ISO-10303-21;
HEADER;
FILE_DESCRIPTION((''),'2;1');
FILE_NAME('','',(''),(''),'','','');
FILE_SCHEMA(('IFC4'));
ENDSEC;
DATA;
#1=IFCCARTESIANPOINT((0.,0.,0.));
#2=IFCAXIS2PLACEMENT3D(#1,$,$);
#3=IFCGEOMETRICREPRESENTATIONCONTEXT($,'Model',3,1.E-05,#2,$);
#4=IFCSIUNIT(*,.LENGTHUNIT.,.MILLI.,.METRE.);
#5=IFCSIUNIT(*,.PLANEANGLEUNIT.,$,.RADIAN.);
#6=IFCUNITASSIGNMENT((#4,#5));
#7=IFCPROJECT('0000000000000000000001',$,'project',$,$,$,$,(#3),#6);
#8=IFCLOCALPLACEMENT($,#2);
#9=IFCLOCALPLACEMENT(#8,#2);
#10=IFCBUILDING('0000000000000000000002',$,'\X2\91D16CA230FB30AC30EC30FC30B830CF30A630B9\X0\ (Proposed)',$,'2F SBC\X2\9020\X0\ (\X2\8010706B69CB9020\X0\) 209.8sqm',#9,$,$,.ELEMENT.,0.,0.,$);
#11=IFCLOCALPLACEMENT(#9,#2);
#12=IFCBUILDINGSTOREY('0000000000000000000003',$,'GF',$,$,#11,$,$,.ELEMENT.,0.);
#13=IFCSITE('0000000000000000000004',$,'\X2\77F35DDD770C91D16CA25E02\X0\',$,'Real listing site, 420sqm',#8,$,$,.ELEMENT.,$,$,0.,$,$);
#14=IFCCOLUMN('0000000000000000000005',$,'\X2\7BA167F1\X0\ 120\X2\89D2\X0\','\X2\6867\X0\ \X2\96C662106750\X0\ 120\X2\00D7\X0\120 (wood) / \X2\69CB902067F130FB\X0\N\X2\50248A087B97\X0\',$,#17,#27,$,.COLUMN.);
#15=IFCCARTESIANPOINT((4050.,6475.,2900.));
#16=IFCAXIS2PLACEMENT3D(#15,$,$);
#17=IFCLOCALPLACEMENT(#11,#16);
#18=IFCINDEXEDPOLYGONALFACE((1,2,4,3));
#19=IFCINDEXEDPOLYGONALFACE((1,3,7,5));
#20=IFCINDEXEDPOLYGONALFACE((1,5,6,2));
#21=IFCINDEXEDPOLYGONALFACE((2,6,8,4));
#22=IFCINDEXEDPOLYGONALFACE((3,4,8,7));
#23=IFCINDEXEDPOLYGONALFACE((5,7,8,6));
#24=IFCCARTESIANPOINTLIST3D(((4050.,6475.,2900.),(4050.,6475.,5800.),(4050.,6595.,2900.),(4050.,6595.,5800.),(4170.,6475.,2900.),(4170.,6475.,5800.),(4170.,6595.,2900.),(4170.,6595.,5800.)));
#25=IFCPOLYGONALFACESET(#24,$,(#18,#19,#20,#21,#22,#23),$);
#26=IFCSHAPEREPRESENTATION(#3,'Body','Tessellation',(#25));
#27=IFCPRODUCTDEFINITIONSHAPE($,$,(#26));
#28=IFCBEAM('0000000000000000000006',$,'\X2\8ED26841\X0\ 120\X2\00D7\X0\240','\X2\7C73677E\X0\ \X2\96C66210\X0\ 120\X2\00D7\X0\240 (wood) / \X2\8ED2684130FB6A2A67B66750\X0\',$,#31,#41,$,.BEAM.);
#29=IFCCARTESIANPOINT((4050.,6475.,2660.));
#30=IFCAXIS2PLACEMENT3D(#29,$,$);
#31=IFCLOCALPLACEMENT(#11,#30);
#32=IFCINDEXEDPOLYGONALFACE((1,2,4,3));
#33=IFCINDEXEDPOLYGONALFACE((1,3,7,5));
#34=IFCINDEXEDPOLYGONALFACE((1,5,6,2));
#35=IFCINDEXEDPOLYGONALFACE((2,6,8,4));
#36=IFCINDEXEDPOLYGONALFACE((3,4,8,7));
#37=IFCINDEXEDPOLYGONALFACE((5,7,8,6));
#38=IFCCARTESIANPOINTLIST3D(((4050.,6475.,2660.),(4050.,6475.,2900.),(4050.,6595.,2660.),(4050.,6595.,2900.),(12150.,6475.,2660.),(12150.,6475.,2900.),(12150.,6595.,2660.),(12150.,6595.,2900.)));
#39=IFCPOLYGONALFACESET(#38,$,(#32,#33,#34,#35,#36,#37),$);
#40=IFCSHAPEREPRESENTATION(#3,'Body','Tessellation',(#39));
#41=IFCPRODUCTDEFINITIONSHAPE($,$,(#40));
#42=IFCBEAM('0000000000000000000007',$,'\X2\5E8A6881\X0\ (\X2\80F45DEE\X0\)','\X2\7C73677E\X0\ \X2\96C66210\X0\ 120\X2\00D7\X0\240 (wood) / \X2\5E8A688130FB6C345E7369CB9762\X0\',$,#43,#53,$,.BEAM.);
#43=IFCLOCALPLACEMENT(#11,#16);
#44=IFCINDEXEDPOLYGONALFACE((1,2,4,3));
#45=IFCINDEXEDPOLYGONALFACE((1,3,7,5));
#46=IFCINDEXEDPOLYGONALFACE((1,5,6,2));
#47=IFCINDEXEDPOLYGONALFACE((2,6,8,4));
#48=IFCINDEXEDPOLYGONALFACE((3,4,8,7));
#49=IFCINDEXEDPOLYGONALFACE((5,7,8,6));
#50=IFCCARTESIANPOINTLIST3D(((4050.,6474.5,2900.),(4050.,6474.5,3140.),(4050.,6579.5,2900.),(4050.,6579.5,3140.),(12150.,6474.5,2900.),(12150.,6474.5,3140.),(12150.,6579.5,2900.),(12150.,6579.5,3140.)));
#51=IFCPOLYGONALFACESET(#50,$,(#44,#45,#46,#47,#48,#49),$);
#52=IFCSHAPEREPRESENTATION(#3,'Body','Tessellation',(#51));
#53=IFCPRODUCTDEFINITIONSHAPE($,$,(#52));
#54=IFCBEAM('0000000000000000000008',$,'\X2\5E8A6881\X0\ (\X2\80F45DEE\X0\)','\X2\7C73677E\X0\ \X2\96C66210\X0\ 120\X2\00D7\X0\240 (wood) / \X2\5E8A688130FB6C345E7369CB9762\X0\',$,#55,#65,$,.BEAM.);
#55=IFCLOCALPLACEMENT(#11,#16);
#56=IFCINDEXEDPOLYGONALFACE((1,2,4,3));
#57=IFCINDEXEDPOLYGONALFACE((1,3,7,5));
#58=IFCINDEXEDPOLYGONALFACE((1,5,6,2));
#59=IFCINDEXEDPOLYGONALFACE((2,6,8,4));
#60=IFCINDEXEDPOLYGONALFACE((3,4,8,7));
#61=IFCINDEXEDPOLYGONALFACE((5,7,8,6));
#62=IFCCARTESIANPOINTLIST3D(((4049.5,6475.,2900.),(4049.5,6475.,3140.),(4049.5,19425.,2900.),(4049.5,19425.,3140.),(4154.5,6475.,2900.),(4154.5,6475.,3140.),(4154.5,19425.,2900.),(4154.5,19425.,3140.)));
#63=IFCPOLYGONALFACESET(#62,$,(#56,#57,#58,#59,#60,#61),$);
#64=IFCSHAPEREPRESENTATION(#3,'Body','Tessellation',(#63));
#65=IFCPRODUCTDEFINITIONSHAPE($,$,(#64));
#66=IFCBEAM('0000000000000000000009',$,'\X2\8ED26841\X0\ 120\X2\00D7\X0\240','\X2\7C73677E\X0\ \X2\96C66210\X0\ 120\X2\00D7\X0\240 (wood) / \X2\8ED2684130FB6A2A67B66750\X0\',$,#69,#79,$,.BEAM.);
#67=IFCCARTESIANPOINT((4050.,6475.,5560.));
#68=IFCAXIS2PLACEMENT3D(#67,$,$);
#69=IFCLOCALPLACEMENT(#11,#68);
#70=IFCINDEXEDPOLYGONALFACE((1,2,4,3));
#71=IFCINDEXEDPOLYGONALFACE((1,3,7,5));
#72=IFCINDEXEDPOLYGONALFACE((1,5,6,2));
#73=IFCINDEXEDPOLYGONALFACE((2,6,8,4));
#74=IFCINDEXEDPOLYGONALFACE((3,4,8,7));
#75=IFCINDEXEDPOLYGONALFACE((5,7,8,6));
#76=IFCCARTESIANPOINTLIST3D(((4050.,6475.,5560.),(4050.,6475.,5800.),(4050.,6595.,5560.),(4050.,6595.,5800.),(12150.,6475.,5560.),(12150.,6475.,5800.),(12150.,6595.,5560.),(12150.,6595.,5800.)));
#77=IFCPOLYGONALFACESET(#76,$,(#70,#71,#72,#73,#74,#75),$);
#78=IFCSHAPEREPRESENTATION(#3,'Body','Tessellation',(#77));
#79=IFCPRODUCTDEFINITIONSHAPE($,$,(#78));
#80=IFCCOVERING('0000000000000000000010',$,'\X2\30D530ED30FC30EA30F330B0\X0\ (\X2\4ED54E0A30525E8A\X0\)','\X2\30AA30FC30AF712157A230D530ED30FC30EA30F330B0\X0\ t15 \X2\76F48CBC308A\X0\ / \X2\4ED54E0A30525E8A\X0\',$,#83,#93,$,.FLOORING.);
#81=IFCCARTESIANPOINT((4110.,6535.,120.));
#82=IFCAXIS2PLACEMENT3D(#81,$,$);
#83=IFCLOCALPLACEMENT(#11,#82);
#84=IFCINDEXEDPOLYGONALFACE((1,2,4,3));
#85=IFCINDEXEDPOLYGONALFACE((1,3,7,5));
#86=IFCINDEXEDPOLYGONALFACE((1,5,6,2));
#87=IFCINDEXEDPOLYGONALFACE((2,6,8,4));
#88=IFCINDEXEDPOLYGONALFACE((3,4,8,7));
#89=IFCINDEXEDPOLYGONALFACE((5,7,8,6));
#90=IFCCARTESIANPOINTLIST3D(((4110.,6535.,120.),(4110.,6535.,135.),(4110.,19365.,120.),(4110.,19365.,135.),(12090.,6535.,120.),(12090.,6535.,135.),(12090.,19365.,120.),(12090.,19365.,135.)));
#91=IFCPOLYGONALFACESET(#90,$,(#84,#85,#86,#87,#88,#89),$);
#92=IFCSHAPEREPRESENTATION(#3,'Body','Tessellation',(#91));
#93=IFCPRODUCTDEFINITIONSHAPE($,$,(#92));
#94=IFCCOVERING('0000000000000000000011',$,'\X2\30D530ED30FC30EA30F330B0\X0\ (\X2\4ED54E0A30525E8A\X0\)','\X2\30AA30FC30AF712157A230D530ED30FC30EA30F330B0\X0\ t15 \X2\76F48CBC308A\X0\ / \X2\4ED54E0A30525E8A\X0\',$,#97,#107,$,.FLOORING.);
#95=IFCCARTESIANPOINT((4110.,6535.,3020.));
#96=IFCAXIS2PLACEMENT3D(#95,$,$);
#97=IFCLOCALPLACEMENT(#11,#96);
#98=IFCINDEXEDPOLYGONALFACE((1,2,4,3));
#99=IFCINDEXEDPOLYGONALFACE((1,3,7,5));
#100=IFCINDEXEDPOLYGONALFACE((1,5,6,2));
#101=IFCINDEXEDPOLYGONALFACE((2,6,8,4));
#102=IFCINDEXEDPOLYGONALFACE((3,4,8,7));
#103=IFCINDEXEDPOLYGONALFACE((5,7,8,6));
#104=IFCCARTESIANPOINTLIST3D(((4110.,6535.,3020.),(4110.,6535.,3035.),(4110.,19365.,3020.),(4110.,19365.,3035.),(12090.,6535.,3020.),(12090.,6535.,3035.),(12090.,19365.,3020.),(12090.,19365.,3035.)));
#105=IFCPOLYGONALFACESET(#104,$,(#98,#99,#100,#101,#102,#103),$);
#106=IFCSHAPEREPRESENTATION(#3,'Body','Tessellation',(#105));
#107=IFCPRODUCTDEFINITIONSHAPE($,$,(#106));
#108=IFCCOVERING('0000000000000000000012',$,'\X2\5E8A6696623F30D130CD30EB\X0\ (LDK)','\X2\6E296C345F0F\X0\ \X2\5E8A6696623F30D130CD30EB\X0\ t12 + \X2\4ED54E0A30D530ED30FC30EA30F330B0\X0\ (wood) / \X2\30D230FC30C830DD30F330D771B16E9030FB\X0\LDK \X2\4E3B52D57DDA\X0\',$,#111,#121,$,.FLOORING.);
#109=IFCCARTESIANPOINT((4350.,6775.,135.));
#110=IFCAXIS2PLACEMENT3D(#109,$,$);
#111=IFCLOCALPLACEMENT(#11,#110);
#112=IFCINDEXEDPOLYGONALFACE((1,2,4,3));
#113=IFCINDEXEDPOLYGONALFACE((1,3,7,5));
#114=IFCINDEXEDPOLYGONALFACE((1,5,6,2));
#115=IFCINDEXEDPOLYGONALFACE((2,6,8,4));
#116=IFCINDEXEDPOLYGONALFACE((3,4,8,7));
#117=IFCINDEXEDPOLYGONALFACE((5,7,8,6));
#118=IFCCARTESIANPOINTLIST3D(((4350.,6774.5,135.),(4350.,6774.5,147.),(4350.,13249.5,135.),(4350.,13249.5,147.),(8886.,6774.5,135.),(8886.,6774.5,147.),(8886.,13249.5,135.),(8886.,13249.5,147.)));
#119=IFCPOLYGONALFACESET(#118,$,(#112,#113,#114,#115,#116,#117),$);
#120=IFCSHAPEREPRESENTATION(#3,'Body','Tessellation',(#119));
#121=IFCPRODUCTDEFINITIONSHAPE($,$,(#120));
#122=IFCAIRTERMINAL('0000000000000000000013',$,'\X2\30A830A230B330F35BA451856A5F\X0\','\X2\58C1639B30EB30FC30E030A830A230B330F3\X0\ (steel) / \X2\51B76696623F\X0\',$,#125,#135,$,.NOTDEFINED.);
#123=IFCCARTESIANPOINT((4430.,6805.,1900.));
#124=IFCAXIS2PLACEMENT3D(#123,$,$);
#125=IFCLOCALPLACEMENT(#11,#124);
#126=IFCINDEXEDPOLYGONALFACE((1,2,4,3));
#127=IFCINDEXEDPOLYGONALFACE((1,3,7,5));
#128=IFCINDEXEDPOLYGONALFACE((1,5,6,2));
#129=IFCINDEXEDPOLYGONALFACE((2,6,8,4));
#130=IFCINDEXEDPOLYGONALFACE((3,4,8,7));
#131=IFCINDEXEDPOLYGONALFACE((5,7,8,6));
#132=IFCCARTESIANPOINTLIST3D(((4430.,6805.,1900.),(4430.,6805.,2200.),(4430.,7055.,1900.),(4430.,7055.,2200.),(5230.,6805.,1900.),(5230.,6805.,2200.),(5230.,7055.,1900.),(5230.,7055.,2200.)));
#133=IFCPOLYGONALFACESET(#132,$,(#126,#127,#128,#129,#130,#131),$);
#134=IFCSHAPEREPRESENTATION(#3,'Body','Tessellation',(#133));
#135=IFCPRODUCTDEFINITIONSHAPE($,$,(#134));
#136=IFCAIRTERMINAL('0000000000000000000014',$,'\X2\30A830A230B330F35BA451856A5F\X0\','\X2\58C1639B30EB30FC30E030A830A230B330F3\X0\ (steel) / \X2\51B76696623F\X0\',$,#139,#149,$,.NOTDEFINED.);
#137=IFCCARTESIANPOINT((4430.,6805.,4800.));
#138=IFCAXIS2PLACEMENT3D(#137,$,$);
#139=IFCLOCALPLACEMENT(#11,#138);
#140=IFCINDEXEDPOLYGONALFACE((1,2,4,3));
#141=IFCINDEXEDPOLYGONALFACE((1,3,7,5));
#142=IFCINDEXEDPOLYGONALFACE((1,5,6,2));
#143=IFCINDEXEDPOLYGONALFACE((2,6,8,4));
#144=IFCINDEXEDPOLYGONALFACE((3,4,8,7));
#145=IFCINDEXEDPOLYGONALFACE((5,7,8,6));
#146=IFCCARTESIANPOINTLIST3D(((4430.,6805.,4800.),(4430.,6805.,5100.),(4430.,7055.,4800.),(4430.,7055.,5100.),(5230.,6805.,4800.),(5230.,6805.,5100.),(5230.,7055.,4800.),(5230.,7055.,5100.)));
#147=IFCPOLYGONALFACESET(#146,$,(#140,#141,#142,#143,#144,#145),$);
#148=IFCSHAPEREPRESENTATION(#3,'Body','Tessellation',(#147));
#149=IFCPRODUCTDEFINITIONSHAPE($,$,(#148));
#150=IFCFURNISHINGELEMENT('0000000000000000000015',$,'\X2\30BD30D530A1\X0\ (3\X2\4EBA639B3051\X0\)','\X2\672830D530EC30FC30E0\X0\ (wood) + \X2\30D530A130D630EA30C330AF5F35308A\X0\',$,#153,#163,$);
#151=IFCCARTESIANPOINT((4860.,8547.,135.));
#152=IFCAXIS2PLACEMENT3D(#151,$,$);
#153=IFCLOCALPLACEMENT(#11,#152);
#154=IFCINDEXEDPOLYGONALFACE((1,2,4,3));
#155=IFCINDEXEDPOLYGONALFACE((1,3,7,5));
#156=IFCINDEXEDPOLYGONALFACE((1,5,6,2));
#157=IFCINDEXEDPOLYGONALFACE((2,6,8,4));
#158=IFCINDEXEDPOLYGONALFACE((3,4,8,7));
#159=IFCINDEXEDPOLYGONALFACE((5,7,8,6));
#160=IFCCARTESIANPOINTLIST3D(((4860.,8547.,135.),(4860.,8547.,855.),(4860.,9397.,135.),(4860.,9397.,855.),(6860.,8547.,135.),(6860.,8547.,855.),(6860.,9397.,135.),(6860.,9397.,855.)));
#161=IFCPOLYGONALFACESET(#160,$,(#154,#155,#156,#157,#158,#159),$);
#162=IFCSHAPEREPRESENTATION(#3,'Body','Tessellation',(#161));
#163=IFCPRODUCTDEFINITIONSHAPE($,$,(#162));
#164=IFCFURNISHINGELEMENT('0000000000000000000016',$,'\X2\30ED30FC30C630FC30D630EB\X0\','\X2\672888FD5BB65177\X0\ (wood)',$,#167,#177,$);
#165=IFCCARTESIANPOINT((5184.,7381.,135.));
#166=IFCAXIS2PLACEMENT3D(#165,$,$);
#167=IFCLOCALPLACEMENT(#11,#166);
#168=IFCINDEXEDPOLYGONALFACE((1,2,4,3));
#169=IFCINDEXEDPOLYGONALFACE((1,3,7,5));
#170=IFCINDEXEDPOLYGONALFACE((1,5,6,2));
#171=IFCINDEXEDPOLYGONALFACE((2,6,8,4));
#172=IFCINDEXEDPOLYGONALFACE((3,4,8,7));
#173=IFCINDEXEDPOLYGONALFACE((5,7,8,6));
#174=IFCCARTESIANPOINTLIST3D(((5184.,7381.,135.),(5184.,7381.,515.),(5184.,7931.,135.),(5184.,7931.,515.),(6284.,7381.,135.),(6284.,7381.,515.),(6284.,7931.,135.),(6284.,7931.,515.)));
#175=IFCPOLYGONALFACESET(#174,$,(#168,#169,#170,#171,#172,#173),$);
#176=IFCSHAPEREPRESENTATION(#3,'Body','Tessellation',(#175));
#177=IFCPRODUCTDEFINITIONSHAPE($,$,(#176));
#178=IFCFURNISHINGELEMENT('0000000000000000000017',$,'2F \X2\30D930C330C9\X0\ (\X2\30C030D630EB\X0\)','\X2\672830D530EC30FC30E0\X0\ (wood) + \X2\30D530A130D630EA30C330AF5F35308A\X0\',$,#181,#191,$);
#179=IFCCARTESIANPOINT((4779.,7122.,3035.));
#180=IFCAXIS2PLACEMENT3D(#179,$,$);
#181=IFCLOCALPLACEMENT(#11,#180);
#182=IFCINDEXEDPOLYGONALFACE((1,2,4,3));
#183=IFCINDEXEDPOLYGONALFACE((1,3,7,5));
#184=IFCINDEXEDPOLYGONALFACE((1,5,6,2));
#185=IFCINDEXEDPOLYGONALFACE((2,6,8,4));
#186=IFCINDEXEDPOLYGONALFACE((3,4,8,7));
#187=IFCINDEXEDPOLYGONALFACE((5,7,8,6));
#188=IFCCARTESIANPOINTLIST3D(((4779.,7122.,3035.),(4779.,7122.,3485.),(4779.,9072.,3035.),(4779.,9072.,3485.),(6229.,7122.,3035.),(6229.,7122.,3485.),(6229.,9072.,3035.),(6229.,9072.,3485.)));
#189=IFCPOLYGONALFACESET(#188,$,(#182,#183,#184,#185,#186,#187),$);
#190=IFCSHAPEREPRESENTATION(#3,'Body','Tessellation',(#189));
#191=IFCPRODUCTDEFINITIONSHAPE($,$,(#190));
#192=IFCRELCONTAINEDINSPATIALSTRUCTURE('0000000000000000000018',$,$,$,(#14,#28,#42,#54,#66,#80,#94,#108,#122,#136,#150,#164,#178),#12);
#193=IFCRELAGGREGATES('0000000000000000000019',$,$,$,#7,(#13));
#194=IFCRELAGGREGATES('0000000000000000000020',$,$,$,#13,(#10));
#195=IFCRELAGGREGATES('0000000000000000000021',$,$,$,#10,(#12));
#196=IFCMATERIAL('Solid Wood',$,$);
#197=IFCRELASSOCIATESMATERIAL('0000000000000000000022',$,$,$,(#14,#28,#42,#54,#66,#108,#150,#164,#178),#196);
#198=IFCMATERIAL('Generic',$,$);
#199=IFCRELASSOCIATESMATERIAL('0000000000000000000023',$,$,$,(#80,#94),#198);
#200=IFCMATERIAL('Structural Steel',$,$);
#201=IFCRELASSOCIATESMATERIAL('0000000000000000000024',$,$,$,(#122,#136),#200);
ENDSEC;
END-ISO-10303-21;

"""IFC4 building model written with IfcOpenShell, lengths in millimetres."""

from ifc_helpers import new_model, si_unit, frame, frame_2d, origin, place, context, project, spatial, rectangle, extrude, material, element, save


model = new_model("IFC4")

# Units and contexts
model_context = context("Model", 3, precision=1e-05, world=origin())
ifc_project = project(units=[si_unit("LENGTHUNIT", "METRE", prefix="MILLI"), si_unit("PLANEANGLEUNIT", "RADIAN")], contexts=[model_context])

# Site, building, storey
site_placement = place(None, origin())
site = spatial("IfcSite", under=ifc_project, at=site_placement, Name="石川県金沢市", ObjectType="Real listing site, 420sqm", CompositionType="ELEMENT", RefElevation=0.0)
building_placement = place(site_placement, origin())
building = spatial("IfcBuilding", under=site, at=building_placement, Name="金沢・ガレージハウス (Proposed)", ObjectType="2F SBC造 (耐火構造) 209.8sqm", CompositionType="ELEMENT", ElevationOfRefHeight=0.0, ElevationOfTerrain=0.0)
storey_placement = place(building_placement, origin())
storey = spatial("IfcBuildingStorey", under=building, at=storey_placement, Name="GF", CompositionType="ELEMENT", Elevation=0.0)

# Column
ifc_material_1 = material(Name="Solid Wood")
column_1_placement = place(storey_placement, frame((4050.0, 6475.0, 2900.0)))
element("IfcColumn", 1, at=column_1_placement, inside=storey, material=ifc_material_1, Name="管柱 120角", Description="桧 集成材 120×120 (wood) / 構造柱・N値計算", PredefinedType="COLUMN", context=model_context, shape_type="SweptSolid", body=[
    extrude(rectangle(XDim=120.0, YDim=120.0, at=frame_2d((60.0, 60.0))), frame((4050.0, 6475.0, 2900.0)), (0.0, 0.0, 1.0), 2900.0),
])

# Beams
beam_1_placement = place(storey_placement, frame((4050.0, 6475.0, 2660.0)))
element("IfcBeam", 2, at=beam_1_placement, inside=storey, material=ifc_material_1, Name="軒桁 120×240", Description="米松 集成 120×240 (wood) / 軒桁・横架材", PredefinedType="BEAM", context=model_context, shape_type="SweptSolid", body=[
    extrude(rectangle(XDim=8100.0, YDim=120.0, at=frame_2d((4050.0, 60.0))), frame((4050.0, 6475.0, 2660.0)), (0.0, 0.0, 1.0), 240.0),
])
beam_2_placement = place(storey_placement, frame((4050.0, 6475.0, 2900.0)))
element("IfcBeam", 3, at=beam_2_placement, inside=storey, material=ifc_material_1, Name="床梁 (胴差)", Description="米松 集成 120×240 (wood) / 床梁・水平構面", PredefinedType="BEAM", context=model_context, shape_type="SweptSolid", body=[
    extrude(rectangle(XDim=8100.0, YDim=105.0, at=frame_2d((4050.0, 52.0))), frame((4050.0, 6475.0, 2900.0)), (0.0, 0.0, 1.0), 240.0),
])
beam_3_placement = place(storey_placement, frame((4050.0, 6475.0, 2900.0)))
element("IfcBeam", 4, at=beam_3_placement, inside=storey, material=ifc_material_1, Name="床梁 (胴差)", Description="米松 集成 120×240 (wood) / 床梁・水平構面", PredefinedType="BEAM", context=model_context, shape_type="SweptSolid", body=[
    extrude(rectangle(XDim=105.0, YDim=12950.0, at=frame_2d((52.0, 6475.0))), frame((4050.0, 6475.0, 2900.0)), (0.0, 0.0, 1.0), 240.0),
])
beam_4_placement = place(storey_placement, frame((4050.0, 6475.0, 5560.0)))
element("IfcBeam", 5, at=beam_4_placement, inside=storey, material=ifc_material_1, Name="軒桁 120×240", Description="米松 集成 120×240 (wood) / 軒桁・横架材", PredefinedType="BEAM", context=model_context, shape_type="SweptSolid", body=[
    extrude(rectangle(XDim=8100.0, YDim=120.0, at=frame_2d((4050.0, 60.0))), frame((4050.0, 6475.0, 5560.0)), (0.0, 0.0, 1.0), 240.0),
])

# Coverings
ifc_material_2 = material(Name="Generic")
covering_1_placement = place(storey_placement, frame((4110.0, 6535.0, 120.0)))
element("IfcCovering", 6, at=covering_1_placement, inside=storey, material=ifc_material_2, Name="フローリング (仕上げ床)", Description="オーク無垢フローリング t15 直貼り / 仕上げ床", PredefinedType="FLOORING", context=model_context, shape_type="SweptSolid", body=[
    extrude(rectangle(XDim=7980.0, YDim=12830.0, at=frame_2d((3990.0, 6415.0))), frame((4110.0, 6535.0, 120.0)), (0.0, 0.0, 1.0), 15.0),
])
covering_2_placement = place(storey_placement, frame((4110.0, 6535.0, 3020.0)))
element("IfcCovering", 7, at=covering_2_placement, inside=storey, material=ifc_material_2, Name="フローリング (仕上げ床)", Description="オーク無垢フローリング t15 直貼り / 仕上げ床", PredefinedType="FLOORING", context=model_context, shape_type="SweptSolid", body=[
    extrude(rectangle(XDim=7980.0, YDim=12830.0, at=frame_2d((3990.0, 6415.0))), frame((4110.0, 6535.0, 3020.0)), (0.0, 0.0, 1.0), 15.0),
])
covering_3_placement = place(storey_placement, frame((4350.0, 6775.0, 135.0)))
element("IfcCovering", 8, at=covering_3_placement, inside=storey, material=ifc_material_1, Name="床暖房パネル (LDK)", Description="温水式 床暖房パネル t12 + 仕上フローリング (wood) / ヒートポンプ熱源・LDK 主動線", PredefinedType="FLOORING", context=model_context, shape_type="SweptSolid", body=[
    extrude(rectangle(XDim=4536.0, YDim=6475.0, at=frame_2d((2268.0, 3237.0))), frame((4350.0, 6775.0, 135.0)), (0.0, 0.0, 1.0), 12.0),
])

# Air terminals
ifc_material_3 = material(Name="Structural Steel")
air_terminal_1_placement = place(storey_placement, frame((4430.0, 6805.0, 1900.0)))
element("IfcAirTerminal", 9, at=air_terminal_1_placement, inside=storey, material=ifc_material_3, Name="エアコン室内機", Description="壁掛ルームエアコン (steel) / 冷暖房", PredefinedType="NOTDEFINED", context=model_context, shape_type="SweptSolid", body=[
    extrude(rectangle(XDim=800.0, YDim=250.0, at=frame_2d((400.0, 125.0))), frame((4430.0, 6805.0, 1900.0)), (0.0, 0.0, 1.0), 300.0),
])
air_terminal_2_placement = place(storey_placement, frame((4430.0, 6805.0, 4800.0)))
element("IfcAirTerminal", 10, at=air_terminal_2_placement, inside=storey, material=ifc_material_3, Name="エアコン室内機", Description="壁掛ルームエアコン (steel) / 冷暖房", PredefinedType="NOTDEFINED", context=model_context, shape_type="SweptSolid", body=[
    extrude(rectangle(XDim=800.0, YDim=250.0, at=frame_2d((400.0, 125.0))), frame((4430.0, 6805.0, 4800.0)), (0.0, 0.0, 1.0), 300.0),
])

# Furnishing elements
furnishing_1_placement = place(storey_placement, frame((4860.0, 8547.0, 135.0)))
element("IfcFurnishingElement", 11, at=furnishing_1_placement, inside=storey, material=ifc_material_1, Name="ソファ (3人掛け)", Description="木フレーム (wood) + ファブリック張り", context=model_context, shape_type="SweptSolid", body=[
    extrude(rectangle(XDim=2000.0, YDim=850.0, at=frame_2d((1000.0, 425.0))), frame((4860.0, 8547.0, 135.0)), (0.0, 0.0, 1.0), 720.0),
])
furnishing_2_placement = place(storey_placement, frame((5184.0, 7381.0, 135.0)))
element("IfcFurnishingElement", 12, at=furnishing_2_placement, inside=storey, material=ifc_material_1, Name="ローテーブル", Description="木製家具 (wood)", context=model_context, shape_type="SweptSolid", body=[
    extrude(rectangle(XDim=1100.0, YDim=550.0, at=frame_2d((550.0, 275.0))), frame((5184.0, 7381.0, 135.0)), (0.0, 0.0, 1.0), 380.0),
])
furnishing_3_placement = place(storey_placement, frame((4779.0, 7122.0, 3035.0)))
element("IfcFurnishingElement", 13, at=furnishing_3_placement, inside=storey, material=ifc_material_1, Name="2F ベッド (ダブル)", Description="木フレーム (wood) + ファブリック張り", context=model_context, shape_type="SweptSolid", body=[
    extrude(rectangle(XDim=1450.0, YDim=1950.0, at=frame_2d((725.0, 975.0))), frame((4779.0, 7122.0, 3035.0)), (0.0, 0.0, 1.0), 450.0),
])

save(model, "model.ifc")
